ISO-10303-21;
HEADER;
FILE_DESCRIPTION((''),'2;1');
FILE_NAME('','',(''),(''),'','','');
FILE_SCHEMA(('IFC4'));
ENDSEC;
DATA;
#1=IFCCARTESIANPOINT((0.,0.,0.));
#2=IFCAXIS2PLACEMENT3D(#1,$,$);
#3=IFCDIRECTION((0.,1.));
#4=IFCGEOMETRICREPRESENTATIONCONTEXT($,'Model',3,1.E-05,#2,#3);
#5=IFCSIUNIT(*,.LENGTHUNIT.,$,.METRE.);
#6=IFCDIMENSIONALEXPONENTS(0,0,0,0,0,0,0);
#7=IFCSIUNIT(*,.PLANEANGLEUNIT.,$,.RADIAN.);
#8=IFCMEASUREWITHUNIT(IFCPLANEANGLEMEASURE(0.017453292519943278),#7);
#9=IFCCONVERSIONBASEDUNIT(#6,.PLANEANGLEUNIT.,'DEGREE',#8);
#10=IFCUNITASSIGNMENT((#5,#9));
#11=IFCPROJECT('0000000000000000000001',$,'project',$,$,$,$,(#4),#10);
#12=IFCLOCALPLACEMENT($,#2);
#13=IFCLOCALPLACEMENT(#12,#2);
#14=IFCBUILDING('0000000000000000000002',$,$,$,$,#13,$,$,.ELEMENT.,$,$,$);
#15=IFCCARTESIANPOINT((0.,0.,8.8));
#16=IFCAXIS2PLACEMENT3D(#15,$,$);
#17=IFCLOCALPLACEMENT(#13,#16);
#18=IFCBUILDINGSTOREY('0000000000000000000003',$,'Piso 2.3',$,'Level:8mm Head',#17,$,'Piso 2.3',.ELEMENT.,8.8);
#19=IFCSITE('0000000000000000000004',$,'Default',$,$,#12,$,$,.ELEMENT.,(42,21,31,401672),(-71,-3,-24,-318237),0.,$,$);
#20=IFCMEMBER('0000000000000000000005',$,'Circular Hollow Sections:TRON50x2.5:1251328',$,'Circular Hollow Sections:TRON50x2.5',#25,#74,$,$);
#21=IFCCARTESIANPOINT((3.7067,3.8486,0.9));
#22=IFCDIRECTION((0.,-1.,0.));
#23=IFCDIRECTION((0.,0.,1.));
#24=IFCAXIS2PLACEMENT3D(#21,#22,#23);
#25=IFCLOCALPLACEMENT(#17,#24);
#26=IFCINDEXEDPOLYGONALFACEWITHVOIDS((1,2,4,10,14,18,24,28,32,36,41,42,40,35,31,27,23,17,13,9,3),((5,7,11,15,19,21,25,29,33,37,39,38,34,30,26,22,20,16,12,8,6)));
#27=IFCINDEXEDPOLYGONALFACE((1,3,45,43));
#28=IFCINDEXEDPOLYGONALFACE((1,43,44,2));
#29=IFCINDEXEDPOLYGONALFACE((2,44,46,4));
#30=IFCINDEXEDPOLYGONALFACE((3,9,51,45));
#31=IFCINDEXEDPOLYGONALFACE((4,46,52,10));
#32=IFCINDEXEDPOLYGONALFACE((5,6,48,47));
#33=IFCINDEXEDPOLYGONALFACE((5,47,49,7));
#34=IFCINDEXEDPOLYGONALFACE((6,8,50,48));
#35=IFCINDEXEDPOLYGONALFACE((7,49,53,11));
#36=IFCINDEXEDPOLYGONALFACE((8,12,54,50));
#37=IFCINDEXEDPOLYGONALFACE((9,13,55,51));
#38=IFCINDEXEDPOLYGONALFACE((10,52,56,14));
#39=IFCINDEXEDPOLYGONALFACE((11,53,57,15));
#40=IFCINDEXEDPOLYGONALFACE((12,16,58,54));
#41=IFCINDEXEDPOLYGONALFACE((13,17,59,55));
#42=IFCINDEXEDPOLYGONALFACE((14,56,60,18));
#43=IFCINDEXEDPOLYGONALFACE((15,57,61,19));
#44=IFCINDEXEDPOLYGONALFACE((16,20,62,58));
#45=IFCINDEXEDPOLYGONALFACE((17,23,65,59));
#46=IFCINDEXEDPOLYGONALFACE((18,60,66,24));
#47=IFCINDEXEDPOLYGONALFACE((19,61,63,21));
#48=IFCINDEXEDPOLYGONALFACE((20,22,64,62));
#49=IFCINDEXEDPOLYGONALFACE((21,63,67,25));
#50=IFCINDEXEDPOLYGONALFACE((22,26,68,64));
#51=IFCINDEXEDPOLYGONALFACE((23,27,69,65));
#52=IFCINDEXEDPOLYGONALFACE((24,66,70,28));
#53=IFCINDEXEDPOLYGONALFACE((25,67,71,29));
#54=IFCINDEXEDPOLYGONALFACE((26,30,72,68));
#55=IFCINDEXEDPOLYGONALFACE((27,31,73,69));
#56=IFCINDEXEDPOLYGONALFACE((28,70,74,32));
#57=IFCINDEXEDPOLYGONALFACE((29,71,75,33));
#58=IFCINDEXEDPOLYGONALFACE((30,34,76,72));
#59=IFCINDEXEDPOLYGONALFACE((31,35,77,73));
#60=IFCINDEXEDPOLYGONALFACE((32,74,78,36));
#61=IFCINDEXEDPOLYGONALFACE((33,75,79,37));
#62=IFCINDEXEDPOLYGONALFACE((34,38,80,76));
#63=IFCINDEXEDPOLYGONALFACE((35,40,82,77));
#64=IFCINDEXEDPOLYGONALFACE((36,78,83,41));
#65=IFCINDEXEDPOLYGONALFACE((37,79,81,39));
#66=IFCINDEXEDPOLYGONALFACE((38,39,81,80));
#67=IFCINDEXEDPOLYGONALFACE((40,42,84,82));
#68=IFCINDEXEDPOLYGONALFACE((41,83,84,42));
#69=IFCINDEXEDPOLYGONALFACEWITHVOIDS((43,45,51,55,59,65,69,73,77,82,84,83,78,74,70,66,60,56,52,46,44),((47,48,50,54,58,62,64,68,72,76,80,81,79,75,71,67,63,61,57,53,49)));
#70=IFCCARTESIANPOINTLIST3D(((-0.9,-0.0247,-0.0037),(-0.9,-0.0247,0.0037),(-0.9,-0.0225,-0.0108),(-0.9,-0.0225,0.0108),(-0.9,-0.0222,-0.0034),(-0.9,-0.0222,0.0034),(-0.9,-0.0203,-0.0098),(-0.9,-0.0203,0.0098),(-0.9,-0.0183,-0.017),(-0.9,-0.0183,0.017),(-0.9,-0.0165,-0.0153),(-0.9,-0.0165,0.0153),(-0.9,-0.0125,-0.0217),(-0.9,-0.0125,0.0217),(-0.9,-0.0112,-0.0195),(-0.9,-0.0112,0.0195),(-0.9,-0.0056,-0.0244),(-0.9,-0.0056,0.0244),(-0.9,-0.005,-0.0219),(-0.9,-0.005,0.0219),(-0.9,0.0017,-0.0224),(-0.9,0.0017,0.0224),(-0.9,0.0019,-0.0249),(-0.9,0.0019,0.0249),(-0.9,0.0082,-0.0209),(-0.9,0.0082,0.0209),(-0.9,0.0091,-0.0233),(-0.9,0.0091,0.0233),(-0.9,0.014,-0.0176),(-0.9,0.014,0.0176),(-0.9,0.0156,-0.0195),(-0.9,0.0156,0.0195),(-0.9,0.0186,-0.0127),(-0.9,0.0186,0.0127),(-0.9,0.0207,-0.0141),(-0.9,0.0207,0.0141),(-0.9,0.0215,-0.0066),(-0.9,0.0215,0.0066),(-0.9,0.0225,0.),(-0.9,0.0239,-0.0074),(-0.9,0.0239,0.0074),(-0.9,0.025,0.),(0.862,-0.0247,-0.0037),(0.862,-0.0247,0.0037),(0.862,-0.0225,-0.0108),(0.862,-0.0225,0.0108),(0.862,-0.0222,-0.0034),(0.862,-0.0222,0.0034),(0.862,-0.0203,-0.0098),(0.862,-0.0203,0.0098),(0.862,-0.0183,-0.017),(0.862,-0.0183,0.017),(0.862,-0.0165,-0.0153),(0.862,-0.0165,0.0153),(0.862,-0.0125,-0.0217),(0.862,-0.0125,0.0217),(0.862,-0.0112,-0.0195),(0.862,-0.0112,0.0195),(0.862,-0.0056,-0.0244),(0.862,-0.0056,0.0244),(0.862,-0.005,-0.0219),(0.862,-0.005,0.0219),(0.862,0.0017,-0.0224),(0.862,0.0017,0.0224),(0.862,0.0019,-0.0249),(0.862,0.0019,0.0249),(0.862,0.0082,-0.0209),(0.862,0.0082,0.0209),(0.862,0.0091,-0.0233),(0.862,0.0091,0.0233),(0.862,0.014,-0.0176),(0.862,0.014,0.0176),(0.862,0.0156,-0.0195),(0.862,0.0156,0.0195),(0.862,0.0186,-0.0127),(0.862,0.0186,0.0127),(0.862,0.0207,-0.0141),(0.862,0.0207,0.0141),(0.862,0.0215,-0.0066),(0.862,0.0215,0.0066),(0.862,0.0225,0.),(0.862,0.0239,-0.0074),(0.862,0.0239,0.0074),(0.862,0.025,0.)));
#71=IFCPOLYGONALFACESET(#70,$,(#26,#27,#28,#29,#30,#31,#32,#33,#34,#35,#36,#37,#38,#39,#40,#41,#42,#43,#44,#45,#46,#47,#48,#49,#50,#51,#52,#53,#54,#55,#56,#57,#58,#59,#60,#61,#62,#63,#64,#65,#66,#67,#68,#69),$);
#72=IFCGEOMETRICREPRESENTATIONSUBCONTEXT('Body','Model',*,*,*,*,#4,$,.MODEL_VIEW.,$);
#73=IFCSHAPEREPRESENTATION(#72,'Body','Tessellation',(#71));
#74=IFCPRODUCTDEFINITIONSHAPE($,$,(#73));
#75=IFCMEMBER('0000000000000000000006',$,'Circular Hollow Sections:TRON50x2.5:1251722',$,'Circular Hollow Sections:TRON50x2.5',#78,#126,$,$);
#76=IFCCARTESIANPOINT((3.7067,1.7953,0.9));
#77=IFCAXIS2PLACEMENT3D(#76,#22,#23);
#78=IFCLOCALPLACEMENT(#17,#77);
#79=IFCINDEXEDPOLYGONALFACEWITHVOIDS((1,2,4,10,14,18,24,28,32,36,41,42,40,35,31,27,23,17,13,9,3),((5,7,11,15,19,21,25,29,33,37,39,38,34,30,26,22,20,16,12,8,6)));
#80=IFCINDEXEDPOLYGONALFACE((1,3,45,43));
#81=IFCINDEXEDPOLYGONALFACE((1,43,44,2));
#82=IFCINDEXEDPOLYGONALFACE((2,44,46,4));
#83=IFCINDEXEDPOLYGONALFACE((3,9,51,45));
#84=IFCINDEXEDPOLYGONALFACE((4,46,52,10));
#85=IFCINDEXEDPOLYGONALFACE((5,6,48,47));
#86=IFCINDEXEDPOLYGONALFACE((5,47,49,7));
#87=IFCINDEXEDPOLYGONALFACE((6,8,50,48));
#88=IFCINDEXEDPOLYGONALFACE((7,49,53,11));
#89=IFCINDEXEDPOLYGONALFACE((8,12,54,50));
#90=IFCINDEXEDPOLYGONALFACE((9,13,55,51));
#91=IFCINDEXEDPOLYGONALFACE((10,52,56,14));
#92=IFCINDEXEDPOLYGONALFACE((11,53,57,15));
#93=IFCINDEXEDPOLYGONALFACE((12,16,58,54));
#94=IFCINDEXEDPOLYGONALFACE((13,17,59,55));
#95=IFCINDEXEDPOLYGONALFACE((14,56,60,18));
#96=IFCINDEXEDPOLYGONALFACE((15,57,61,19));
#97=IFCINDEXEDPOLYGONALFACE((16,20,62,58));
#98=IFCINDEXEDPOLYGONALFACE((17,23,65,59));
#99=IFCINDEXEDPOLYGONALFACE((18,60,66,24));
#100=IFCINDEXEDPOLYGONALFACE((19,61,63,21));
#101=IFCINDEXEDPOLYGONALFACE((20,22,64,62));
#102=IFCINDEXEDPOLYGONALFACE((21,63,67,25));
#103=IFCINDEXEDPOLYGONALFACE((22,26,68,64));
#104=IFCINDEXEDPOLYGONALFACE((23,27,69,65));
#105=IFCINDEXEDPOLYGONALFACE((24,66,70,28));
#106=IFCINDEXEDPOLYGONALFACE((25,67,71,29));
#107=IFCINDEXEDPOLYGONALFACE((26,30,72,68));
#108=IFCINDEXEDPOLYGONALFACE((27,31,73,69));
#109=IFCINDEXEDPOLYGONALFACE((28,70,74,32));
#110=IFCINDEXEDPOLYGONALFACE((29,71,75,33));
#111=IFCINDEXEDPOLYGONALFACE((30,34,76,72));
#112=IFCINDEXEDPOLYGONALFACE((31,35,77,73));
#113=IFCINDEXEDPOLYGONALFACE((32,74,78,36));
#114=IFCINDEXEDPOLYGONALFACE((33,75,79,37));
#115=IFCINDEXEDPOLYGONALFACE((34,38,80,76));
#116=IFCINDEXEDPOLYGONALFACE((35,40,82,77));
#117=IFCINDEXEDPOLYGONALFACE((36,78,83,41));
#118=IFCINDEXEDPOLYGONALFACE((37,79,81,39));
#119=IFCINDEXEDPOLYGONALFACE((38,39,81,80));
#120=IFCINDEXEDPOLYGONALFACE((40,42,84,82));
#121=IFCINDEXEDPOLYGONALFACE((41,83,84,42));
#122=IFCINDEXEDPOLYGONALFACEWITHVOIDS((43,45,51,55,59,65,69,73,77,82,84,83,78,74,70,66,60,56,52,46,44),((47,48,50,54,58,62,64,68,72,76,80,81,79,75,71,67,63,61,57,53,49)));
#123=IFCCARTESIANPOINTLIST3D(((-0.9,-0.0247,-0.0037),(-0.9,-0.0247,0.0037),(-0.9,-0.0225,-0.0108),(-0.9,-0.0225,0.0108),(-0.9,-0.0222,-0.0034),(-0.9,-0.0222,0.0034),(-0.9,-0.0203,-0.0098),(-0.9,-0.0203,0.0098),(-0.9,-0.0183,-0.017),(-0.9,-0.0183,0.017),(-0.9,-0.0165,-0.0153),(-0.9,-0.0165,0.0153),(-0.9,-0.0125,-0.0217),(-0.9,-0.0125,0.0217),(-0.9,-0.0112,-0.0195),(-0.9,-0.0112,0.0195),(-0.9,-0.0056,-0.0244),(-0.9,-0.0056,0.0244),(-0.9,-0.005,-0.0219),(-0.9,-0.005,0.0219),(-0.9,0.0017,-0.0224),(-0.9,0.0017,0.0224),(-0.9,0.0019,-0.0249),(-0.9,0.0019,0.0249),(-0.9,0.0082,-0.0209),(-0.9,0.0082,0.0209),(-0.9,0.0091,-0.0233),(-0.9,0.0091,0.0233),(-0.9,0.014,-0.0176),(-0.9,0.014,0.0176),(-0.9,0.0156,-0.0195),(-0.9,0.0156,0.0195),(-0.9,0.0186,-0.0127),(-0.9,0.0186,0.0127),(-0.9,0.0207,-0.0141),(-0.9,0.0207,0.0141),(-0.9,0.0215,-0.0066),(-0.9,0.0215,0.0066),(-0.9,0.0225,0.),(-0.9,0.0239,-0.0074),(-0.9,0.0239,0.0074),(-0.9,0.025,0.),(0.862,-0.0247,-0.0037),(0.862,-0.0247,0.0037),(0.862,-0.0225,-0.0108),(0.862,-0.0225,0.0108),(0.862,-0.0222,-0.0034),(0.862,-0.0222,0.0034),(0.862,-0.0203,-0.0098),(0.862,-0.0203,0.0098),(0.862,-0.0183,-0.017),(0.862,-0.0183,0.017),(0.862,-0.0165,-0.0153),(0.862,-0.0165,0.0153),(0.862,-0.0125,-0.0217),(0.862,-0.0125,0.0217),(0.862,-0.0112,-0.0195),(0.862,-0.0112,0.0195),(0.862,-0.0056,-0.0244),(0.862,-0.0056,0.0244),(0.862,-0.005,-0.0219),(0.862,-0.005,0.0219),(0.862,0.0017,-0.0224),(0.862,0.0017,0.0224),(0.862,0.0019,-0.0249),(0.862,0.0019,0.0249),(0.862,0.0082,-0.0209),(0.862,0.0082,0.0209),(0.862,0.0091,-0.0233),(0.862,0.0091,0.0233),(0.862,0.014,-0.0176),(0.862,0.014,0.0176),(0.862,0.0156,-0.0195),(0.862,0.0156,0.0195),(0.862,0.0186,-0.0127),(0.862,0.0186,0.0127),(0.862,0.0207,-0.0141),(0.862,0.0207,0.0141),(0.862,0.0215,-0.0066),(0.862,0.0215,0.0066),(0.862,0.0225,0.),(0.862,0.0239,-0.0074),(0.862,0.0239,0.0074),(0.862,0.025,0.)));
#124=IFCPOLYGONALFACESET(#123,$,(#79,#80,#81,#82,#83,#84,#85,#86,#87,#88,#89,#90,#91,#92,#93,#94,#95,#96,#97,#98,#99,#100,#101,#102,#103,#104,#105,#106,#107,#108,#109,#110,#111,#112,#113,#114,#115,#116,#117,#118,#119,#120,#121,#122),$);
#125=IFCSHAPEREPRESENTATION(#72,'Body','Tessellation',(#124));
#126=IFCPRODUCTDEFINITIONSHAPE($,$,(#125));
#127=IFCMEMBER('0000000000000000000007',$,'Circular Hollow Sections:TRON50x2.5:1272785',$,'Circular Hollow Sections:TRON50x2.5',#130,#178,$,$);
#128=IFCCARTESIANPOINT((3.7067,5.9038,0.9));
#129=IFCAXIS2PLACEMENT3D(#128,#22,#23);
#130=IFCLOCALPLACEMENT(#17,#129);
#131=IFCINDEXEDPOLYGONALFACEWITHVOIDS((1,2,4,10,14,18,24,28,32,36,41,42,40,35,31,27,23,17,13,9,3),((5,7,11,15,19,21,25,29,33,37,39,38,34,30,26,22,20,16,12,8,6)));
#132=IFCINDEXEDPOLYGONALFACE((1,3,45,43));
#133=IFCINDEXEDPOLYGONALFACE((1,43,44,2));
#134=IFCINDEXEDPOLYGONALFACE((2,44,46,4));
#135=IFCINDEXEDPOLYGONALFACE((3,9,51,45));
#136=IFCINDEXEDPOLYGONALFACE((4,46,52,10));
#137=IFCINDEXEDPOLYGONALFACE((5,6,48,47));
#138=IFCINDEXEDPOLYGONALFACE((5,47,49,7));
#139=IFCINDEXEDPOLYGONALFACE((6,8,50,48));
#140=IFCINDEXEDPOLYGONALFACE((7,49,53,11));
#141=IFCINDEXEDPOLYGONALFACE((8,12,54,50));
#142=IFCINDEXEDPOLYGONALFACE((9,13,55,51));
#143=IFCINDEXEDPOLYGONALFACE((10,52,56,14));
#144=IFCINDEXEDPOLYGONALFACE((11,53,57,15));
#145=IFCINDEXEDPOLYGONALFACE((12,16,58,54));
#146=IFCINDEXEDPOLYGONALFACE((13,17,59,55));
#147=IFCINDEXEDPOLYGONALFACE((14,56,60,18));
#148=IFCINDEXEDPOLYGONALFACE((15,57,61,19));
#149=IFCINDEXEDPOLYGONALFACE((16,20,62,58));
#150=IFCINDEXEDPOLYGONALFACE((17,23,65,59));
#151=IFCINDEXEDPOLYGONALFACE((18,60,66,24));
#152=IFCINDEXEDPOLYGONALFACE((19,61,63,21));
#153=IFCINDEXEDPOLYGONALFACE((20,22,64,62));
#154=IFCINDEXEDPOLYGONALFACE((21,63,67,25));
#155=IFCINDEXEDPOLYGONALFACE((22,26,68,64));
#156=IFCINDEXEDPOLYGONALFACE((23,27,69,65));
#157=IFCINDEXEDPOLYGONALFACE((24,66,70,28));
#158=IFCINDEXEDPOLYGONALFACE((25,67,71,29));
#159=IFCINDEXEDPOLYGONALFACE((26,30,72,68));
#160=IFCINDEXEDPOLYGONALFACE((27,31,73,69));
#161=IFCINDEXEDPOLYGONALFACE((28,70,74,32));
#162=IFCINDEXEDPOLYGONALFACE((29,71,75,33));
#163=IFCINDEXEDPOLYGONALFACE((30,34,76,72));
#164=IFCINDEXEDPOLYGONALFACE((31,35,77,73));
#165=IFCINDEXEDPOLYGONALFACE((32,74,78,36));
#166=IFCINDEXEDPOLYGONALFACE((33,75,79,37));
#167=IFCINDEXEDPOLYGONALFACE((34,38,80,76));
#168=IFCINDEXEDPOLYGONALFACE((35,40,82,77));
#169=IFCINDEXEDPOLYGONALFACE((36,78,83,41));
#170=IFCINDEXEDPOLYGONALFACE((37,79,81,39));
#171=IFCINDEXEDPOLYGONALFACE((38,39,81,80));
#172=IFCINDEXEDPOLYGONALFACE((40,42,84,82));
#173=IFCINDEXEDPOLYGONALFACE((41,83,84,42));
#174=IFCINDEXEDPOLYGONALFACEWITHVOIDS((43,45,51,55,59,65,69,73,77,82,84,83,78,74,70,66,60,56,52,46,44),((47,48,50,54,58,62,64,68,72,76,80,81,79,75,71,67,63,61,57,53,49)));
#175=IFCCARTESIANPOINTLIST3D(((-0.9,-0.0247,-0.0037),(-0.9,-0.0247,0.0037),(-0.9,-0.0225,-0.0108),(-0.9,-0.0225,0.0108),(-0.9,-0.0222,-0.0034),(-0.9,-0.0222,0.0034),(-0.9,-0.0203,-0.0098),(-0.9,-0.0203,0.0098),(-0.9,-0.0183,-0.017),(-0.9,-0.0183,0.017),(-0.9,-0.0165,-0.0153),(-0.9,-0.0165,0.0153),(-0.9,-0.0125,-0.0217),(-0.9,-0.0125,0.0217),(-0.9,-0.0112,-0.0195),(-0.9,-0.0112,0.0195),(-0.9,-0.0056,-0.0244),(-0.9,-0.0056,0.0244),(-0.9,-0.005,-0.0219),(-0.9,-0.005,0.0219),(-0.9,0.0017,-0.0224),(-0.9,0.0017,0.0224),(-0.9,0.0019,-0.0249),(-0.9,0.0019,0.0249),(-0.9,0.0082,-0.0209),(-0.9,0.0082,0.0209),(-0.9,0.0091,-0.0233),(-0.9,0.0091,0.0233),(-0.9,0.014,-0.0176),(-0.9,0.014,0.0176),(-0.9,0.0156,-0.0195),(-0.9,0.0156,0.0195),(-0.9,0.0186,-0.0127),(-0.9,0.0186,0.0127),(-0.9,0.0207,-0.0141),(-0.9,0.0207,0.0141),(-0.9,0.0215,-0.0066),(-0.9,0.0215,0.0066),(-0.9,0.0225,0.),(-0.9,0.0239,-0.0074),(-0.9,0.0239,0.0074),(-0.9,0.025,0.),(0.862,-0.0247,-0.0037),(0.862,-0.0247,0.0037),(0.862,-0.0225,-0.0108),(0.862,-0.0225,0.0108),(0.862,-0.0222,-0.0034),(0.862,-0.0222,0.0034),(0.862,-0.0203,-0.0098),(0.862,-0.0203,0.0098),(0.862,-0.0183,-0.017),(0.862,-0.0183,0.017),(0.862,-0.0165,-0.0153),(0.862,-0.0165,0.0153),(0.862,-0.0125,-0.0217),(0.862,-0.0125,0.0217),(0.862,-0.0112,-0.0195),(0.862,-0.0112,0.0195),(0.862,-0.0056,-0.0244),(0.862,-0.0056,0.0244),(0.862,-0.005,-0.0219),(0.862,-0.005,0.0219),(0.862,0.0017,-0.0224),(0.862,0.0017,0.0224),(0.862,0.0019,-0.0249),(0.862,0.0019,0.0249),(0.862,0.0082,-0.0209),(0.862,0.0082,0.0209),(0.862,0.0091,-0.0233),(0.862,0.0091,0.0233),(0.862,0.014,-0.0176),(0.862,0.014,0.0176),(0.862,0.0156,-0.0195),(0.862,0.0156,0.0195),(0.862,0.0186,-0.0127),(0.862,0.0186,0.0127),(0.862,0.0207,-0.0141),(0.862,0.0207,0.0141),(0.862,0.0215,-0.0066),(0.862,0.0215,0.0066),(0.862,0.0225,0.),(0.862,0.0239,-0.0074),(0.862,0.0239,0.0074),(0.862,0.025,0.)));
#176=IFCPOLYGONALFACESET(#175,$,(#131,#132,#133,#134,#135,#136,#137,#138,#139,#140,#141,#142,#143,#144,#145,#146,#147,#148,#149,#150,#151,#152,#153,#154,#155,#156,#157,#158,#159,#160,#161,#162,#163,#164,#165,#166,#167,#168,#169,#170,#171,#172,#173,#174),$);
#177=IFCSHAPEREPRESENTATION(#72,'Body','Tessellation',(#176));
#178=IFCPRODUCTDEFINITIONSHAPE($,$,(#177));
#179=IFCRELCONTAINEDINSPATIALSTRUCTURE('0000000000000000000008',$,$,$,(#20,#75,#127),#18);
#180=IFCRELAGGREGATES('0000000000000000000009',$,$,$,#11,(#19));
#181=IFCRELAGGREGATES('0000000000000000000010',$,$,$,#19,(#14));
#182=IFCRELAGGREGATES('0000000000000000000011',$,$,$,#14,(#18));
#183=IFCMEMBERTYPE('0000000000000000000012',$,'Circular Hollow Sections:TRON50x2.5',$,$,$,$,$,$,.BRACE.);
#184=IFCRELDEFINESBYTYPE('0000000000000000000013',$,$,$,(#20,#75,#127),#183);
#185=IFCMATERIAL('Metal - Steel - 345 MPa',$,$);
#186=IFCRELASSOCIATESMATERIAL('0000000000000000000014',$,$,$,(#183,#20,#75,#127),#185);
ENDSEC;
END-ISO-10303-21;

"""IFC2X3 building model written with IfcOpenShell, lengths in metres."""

from ifc_helpers import new_model, entity, si_unit, converted_unit, direction, frame, frame_2d, origin, place, context, subcontext, project, spatial, hollow_circle, extrude, source, transform, mapped, material, type_object, type_shapes, element, save


model = new_model("IFC2X3")

# Units and contexts
model_context = context("Model", 3, precision=1e-05, world=origin(), true_north=direction((0.0, 1.0)))
body_context = subcontext(model_context, "Body", "Model", "MODEL_VIEW")
ifc_project = project(units=[si_unit("LENGTHUNIT", "METRE"), converted_unit("PLANEANGLEUNIT", "DEGREE", entity("IfcPlaneAngleMeasure", 0.017453292519943278), si_unit("PLANEANGLEUNIT", "RADIAN"), dimensions=[0, 0, 0, 0, 0, 0, 0])], contexts=[model_context])

# Site, building, storey
site_placement = place(None, origin())
site = spatial("IfcSite", under=ifc_project, at=site_placement, Name="Default", CompositionType="ELEMENT", RefLatitude=(42, 21, 31, 401672), RefLongitude=(-71, -3, -24, -318237), RefElevation=0.0)
building_placement = place(site_placement, origin())
building = spatial("IfcBuilding", under=site, at=building_placement, CompositionType="ELEMENT")
storey_placement = place(building_placement, frame((0.0, 0.0, 8.8)))
storey = spatial("IfcBuildingStorey", under=building, at=storey_placement, Name="Piso 2.3", ObjectType="Level:8mm Head", LongName="Piso 2.3", CompositionType="ELEMENT", Elevation=8.8)

# Shared definitions
ifc_material_1 = material(Name="Metal - Steel - 345 MPa")

# Members
member_type_1 = type_object("IfcMemberType", Name="Circular Hollow Sections:TRON50x2.5", PredefinedType="BRACE", material=ifc_material_1)
shared_shape_1 = source(origin(), body_context, "Body", "SweptSolid", [
    extrude(hollow_circle(Radius=0.025, WallThickness=0.0025, at=frame_2d((0.0, 0.0), x_axis=(1.0, 0.0))), frame((-0.9, 0.0, 0.0), z_axis=(1.0, 0.0, 0.0), x_axis=(0.0, 1.0, 0.0)), (0.0, 0.0, 1.0), 1.762),
])
type_shapes(member_type_1, [shared_shape_1])
for number, where, z_axis, x_axis, name in (
    (1, (3.7067, 3.8486, 0.9), (0.0, -1.0, 0.0), (0.0, 0.0, 1.0), "Circular Hollow Sections:TRON50x2.5:1251328"),
    (2, (3.7067, 1.7953, 0.9), (0.0, -1.0, 0.0), (0.0, 0.0, 1.0), "Circular Hollow Sections:TRON50x2.5:1251722"),
    (3, (3.7067, 5.9038, 0.9), (0.0, -1.0, 0.0), (0.0, 0.0, 1.0), "Circular Hollow Sections:TRON50x2.5:1272785"),
):
    element("IfcMember", number, at=place(storey_placement, frame(where, z_axis=z_axis, x_axis=x_axis)), inside=storey, type_object=member_type_1, material=ifc_material_1, Name=name, ObjectType="Circular Hollow Sections:TRON50x2.5", context=body_context, shape_type="MappedRepresentation", body=[
        mapped(shared_shape_1, transform((0.0, 0.0, 0.0), scale=1.0)),
    ])

save(model, "model.ifc")
